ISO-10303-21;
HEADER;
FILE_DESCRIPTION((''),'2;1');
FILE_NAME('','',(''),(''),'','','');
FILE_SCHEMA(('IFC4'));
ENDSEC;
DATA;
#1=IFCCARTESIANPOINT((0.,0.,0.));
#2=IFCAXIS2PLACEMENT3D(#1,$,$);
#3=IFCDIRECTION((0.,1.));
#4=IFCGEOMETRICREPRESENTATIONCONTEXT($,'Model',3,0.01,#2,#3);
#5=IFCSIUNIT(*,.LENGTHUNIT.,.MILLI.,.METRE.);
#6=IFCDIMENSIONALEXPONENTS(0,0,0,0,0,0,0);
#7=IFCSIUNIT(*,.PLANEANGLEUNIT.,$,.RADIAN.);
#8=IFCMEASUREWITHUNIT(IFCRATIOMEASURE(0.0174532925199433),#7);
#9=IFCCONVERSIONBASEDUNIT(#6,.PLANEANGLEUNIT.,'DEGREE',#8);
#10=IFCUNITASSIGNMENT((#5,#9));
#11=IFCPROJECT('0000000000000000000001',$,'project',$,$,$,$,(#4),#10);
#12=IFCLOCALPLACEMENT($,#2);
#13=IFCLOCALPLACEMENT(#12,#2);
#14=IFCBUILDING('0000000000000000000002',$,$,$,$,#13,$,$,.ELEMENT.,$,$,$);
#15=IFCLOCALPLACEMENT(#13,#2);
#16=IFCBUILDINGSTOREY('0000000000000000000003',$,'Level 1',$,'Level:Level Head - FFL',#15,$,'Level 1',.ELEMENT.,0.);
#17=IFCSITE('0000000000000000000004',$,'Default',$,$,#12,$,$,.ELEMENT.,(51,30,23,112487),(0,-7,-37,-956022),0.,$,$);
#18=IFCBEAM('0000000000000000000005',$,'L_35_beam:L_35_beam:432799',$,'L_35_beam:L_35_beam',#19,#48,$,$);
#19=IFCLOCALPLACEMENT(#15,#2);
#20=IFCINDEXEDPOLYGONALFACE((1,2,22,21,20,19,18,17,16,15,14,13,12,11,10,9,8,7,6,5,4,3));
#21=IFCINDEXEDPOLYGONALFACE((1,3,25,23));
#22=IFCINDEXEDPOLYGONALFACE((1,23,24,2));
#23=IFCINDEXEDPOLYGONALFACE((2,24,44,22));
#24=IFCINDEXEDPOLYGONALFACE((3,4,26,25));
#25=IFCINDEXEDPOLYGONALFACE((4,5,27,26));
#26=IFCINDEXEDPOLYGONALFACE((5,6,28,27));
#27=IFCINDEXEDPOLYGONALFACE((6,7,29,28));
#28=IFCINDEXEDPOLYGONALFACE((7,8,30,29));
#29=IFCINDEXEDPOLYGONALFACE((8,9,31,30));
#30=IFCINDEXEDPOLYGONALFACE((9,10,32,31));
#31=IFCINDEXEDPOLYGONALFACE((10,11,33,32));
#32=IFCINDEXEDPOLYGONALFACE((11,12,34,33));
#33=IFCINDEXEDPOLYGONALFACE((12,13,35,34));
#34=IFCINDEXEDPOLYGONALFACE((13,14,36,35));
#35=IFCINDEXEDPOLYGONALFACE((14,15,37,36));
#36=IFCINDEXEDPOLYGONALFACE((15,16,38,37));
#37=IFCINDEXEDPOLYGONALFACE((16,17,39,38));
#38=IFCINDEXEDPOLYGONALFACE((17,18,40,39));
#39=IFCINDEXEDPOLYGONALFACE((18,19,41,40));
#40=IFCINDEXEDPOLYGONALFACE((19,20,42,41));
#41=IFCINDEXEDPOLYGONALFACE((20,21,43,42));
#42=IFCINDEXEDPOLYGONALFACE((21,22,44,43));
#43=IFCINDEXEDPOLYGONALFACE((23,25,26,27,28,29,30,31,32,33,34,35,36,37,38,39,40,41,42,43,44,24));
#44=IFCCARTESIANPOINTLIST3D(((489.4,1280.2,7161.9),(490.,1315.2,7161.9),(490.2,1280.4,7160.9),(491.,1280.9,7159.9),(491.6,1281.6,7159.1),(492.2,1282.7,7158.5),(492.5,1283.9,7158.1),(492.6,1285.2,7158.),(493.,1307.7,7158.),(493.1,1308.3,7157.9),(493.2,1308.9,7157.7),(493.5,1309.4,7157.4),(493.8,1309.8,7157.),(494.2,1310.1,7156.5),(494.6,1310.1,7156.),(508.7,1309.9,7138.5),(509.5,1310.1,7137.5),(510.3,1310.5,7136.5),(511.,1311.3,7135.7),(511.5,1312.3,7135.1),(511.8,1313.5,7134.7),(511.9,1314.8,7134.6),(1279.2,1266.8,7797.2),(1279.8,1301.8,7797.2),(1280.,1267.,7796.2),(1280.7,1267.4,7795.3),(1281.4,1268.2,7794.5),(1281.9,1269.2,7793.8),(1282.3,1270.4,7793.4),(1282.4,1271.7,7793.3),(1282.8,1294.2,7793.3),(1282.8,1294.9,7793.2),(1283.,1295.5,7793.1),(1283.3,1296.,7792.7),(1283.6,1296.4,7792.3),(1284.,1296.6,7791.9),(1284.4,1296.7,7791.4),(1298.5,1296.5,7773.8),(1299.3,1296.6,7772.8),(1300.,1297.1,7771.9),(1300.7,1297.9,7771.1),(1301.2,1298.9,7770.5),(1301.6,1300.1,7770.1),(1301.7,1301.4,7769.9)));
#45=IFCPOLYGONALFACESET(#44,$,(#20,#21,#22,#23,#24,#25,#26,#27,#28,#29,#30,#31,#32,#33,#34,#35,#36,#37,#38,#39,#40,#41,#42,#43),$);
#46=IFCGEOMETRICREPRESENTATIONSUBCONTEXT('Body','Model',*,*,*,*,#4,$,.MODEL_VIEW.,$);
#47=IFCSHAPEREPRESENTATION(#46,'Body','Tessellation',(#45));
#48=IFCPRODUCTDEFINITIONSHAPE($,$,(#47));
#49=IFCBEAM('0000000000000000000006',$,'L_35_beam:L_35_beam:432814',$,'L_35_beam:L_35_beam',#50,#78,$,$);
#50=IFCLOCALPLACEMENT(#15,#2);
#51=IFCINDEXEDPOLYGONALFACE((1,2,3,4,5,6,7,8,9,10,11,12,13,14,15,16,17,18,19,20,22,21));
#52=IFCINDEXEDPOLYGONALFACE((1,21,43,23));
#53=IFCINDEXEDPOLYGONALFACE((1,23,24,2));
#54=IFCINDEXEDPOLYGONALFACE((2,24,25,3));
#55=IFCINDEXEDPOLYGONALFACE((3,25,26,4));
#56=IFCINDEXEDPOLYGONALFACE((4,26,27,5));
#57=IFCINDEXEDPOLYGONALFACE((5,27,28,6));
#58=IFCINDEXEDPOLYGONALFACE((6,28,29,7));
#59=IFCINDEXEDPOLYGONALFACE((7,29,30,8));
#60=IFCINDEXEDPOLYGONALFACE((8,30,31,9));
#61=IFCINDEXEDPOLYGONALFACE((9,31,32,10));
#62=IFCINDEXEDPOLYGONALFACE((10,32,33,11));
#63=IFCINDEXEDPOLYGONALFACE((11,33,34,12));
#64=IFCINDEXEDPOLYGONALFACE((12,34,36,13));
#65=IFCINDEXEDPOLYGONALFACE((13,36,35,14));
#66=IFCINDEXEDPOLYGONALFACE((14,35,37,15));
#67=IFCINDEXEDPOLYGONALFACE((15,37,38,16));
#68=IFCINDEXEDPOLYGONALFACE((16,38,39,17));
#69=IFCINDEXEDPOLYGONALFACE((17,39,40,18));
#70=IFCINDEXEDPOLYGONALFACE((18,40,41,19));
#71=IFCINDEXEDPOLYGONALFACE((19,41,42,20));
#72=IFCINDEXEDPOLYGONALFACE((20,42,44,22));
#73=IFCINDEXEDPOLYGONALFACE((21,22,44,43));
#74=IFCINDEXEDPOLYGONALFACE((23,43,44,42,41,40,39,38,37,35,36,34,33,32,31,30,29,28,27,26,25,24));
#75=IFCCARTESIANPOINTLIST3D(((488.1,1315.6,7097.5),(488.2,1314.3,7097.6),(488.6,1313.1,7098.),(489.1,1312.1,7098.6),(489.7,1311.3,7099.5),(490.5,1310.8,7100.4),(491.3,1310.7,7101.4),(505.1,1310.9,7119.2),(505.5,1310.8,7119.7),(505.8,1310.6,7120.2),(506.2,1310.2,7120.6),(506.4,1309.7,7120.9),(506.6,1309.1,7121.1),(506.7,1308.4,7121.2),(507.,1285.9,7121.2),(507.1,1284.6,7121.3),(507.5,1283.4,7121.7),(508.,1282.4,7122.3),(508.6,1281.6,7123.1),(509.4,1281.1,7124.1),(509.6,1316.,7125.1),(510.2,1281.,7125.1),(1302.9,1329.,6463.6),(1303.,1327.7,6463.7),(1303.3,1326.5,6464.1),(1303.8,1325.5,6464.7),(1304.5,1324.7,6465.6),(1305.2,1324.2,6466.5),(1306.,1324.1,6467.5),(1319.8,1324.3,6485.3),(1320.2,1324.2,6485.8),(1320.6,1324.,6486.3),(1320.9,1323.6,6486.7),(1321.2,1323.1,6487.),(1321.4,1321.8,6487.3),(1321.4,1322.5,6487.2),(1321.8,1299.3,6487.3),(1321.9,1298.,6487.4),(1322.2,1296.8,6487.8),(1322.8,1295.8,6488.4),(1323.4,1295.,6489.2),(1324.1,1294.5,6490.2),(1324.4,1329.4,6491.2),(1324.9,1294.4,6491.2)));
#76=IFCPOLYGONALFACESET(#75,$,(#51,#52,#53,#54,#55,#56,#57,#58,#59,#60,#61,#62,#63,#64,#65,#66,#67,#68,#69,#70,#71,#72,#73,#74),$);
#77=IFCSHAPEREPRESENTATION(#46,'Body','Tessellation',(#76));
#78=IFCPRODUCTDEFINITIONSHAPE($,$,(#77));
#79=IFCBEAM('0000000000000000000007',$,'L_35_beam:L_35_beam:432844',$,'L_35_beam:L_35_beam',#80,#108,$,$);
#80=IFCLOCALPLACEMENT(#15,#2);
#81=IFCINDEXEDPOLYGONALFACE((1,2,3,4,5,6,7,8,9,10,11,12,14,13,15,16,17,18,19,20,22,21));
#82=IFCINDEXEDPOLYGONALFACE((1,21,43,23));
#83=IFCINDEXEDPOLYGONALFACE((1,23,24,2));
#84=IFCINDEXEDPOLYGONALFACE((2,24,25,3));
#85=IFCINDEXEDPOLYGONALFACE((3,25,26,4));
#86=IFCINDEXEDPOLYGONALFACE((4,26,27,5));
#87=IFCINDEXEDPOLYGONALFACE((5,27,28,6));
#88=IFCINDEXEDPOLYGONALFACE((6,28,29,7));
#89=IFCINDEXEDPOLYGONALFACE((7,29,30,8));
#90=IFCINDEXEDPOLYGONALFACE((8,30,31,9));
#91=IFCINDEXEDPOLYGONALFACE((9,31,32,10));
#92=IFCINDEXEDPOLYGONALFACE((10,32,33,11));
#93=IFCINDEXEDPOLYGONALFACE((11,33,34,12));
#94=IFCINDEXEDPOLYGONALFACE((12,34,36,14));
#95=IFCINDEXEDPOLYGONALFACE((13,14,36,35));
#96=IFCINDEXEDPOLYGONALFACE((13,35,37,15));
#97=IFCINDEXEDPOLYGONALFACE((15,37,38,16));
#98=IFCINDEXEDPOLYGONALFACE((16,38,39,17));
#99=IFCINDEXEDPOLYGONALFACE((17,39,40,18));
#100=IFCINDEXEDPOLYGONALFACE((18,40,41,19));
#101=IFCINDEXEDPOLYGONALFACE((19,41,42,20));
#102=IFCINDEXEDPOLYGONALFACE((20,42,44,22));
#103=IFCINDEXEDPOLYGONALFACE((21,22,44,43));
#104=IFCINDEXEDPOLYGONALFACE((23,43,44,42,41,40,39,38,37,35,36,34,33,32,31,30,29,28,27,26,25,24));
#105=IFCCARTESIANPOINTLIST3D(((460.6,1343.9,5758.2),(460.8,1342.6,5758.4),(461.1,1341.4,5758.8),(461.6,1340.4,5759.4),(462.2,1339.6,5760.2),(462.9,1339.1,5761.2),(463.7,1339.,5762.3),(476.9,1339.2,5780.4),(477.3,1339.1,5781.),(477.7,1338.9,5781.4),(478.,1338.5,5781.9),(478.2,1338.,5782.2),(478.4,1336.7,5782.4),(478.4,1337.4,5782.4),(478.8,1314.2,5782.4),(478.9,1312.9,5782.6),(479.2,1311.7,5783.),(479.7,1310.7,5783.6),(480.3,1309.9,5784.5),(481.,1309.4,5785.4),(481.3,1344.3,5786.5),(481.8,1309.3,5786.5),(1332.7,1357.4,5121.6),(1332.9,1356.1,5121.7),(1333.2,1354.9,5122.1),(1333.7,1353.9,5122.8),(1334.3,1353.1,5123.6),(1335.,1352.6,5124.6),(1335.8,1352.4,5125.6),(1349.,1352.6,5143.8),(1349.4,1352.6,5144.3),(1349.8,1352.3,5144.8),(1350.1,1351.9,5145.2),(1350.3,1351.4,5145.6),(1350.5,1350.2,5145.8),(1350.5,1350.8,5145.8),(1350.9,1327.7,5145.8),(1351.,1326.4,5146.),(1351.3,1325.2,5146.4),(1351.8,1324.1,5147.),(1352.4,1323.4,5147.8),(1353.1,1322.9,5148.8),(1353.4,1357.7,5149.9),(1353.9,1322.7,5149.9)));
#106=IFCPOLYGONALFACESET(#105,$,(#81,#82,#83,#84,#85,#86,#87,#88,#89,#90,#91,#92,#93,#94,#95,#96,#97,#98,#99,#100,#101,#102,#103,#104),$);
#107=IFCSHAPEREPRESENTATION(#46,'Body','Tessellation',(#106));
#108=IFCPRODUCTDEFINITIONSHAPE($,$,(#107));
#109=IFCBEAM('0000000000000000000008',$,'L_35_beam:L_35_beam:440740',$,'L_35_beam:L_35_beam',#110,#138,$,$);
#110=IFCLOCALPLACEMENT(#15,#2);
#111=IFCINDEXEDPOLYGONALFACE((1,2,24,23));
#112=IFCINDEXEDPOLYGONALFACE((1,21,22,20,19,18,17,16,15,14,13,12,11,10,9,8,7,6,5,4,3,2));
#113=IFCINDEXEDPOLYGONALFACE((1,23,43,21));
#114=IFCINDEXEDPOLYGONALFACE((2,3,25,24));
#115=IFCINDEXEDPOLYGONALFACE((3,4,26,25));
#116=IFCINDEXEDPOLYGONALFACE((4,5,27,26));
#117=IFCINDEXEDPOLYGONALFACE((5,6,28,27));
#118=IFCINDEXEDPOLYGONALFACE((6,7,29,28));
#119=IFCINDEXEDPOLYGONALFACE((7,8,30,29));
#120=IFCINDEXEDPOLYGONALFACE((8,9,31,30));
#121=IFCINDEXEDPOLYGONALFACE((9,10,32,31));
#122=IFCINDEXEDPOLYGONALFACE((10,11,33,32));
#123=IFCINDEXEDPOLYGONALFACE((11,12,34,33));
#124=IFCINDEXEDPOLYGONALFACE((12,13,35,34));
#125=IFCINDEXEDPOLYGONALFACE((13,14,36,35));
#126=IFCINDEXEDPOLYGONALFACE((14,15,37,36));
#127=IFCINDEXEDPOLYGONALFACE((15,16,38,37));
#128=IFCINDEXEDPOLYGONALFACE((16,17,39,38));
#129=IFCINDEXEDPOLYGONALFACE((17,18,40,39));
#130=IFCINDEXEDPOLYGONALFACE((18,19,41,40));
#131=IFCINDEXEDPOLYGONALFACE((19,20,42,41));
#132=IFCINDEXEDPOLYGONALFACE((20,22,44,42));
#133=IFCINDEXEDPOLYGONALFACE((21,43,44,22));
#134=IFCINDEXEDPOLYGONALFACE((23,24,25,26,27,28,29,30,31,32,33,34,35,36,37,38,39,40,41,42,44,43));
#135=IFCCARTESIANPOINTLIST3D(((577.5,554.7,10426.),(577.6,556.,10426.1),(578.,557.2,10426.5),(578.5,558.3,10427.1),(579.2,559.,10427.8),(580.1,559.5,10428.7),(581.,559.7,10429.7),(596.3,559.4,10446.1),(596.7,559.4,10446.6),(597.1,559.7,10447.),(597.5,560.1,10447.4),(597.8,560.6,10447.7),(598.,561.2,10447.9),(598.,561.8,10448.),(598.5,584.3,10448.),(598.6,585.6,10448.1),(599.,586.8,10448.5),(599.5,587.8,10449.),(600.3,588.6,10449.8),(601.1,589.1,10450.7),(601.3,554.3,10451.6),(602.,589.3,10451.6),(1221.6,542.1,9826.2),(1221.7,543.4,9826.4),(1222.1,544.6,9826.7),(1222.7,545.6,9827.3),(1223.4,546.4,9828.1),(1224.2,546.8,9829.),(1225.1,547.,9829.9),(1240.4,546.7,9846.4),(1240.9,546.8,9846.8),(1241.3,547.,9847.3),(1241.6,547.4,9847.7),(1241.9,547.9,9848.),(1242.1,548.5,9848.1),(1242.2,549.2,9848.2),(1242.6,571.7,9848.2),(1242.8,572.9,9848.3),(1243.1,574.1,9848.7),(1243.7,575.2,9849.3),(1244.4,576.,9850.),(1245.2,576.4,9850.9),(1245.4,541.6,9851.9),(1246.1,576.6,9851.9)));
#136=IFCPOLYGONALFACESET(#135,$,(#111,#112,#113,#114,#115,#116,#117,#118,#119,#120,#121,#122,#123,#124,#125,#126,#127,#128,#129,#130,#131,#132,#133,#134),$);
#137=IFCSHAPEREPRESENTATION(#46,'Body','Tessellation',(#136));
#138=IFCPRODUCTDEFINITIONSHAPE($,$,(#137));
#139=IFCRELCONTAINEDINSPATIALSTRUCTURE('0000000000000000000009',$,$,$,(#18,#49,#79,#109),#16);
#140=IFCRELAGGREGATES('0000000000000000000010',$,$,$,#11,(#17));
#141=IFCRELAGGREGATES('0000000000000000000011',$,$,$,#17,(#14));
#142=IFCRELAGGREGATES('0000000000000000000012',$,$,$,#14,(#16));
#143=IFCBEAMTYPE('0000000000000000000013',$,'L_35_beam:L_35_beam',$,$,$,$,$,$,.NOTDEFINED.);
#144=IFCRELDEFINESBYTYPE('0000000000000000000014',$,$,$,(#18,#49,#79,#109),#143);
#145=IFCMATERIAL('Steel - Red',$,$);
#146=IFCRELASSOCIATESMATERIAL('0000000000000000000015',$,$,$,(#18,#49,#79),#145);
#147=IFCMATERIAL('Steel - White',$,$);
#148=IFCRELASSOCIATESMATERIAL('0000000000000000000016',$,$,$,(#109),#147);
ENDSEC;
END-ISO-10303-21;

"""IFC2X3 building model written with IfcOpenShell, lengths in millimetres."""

from ifc_helpers import new_model, entity, si_unit, converted_unit, direction, frame, frame_2d, origin, place, context, subcontext, project, spatial, polyline, circle_curve, parameter, trimmed, segment, composite_curve, outline, extrude, material, type_object, element, save


model = new_model("IFC2X3")

# Units and contexts
model_context = context("Model", 3, precision=0.01, world=origin(), true_north=direction((0.0, 1.0)))
body_context = subcontext(model_context, "Body", "Model", "MODEL_VIEW")
ifc_project = project(units=[si_unit("LENGTHUNIT", "METRE", prefix="MILLI"), converted_unit("PLANEANGLEUNIT", "DEGREE", entity("IfcRatioMeasure", 0.0174532925199433), si_unit("PLANEANGLEUNIT", "RADIAN"), dimensions=[0, 0, 0, 0, 0, 0, 0])], contexts=[model_context])

# Site, building, storey
site_placement = place(None, origin())
site = spatial("IfcSite", under=ifc_project, at=site_placement, Name="Default", CompositionType="ELEMENT", RefLatitude=(51, 30, 23, 112487), RefLongitude=(0, -7, -37, -956022), RefElevation=0.0)
building_placement = place(site_placement, origin())
building = spatial("IfcBuilding", under=site, at=building_placement, CompositionType="ELEMENT")
storey_placement = place(building_placement, origin())
storey = spatial("IfcBuildingStorey", under=building, at=storey_placement, Name="Level 1", ObjectType="Level:Level Head - FFL", LongName="Level 1", CompositionType="ELEMENT", Elevation=0.0)

# Beams
ifc_material_1 = material(Name="Steel - Red")
ifc_material_2 = material(Name="Steel - White")
beam_type_1 = type_object("IfcBeamType", Name="L_35_beam:L_35_beam", PredefinedType="NOTDEFINED")
beam_1_placement = place(storey_placement, frame((476.6, 1323.4, 7128.5), z_axis=(-0.626668, 0.010652, 0.779213), x_axis=(0.779101, -0.013243, 0.626759)))
element("IfcBeam", 1, at=beam_1_placement, inside=storey, type_object=beam_type_1, material=ifc_material_1, Name="L_35_beam:L_35_beam:432799", ObjectType="L_35_beam:L_35_beam", context=body_context, shape_type="SweptSolid", body=[
    extrude(outline(composite_curve([segment(polyline([(-23.2, -11.8), (11.8, -11.8)]), True, "CONTINUOUS"), segment(polyline([(11.8, -11.8), (11.8, 23.2)]), True, "CONTINUOUS"), segment(trimmed(circle_curve(frame_2d((11.8, 18.2), x_axis=(0.0, 1.0)), 5.0), [parameter(0.0)], [parameter(90.0)], True, "PARAMETER"), True, "CONTINUOUS"), segment(polyline([(6.8, 18.2), (6.8, -4.3)]), True, "CONTINUOUS"), segment(trimmed(circle_curve(frame_2d((4.3, -4.3), x_axis=(1.0, 0.0)), 2.5), [parameter(270.0)], [parameter(0.0)], True, "PARAMETER"), False, "CONTINUOUS"), segment(polyline([(4.3, -6.8), (-18.2, -6.8)]), True, "CONTINUOUS"), segment(trimmed(circle_curve(frame_2d((-18.2, -11.8), x_axis=(0.0, 1.0)), 5.0), [parameter(0.0)], [parameter(90.0)], True, "PARAMETER"), True, "CONTINUOUS")], self_intersect=False)), frame((31.5, -19.8, 5.7), z_axis=(1.0, 0.0, 0.0), x_axis=(0.0, 0.0, 1.0)), (0.0, 0.0, 1.0), 1013.7),
])
beam_2_placement = place(storey_placement, frame((476.6, 1323.4, 7128.5), z_axis=(0.61392, 0.010092, 0.789304), x_axis=(0.789197, 0.012974, -0.614003)))
element("IfcBeam", 2, at=beam_2_placement, inside=storey, type_object=beam_type_1, material=ifc_material_1, Name="L_35_beam:L_35_beam:432814", ObjectType="L_35_beam:L_35_beam", context=body_context, shape_type="SweptSolid", body=[
    extrude(outline(composite_curve([segment(polyline([(-23.2, -11.8), (11.8, -11.8)]), True, "CONTINUOUS"), segment(polyline([(11.8, -11.8), (11.8, 23.2)]), True, "CONTINUOUS"), segment(trimmed(circle_curve(frame_2d((11.8, 18.2), x_axis=(0.0, 1.0)), 5.0), [parameter(0.0)], [parameter(90.0)], True, "PARAMETER"), True, "CONTINUOUS"), segment(polyline([(6.8, 18.2), (6.8, -4.3)]), True, "CONTINUOUS"), segment(trimmed(circle_curve(frame_2d((4.3, -4.3), x_axis=(1.0, 0.0)), 2.5), [parameter(270.0)], [parameter(0.0)], True, "PARAMETER"), False, "CONTINUOUS"), segment(polyline([(4.3, -6.8), (-18.2, -6.8)]), True, "CONTINUOUS"), segment(trimmed(circle_curve(frame_2d((-18.2, -11.8), x_axis=(0.0, 1.0)), 5.0), [parameter(0.0)], [parameter(90.0)], True, "PARAMETER"), True, "CONTINUOUS")], self_intersect=False)), frame((28.0, -19.8, 5.7), z_axis=(1.0, 0.0, 0.0), x_axis=(0.0, 0.0, 1.0)), (0.0, 0.0, 1.0), 1032.4),
])
beam_3_placement = place(storey_placement, frame((448.3, 1351.8, 5788.8), z_axis=(0.589494, 0.009093, 0.807721), x_axis=(0.807625, 0.012457, -0.589564)))
element("IfcBeam", 3, at=beam_3_placement, inside=storey, type_object=beam_type_1, material=ifc_material_1, Name="L_35_beam:L_35_beam:432844", ObjectType="L_35_beam:L_35_beam", context=body_context, shape_type="SweptSolid", body=[
    extrude(outline(composite_curve([segment(polyline([(-23.2, -11.8), (11.8, -11.8)]), True, "CONTINUOUS"), segment(polyline([(11.8, -11.8), (11.8, 23.2)]), True, "CONTINUOUS"), segment(trimmed(circle_curve(frame_2d((11.8, 18.2), x_axis=(0.0, 1.0)), 5.0), [parameter(0.0)], [parameter(90.0)], True, "PARAMETER"), True, "CONTINUOUS"), segment(polyline([(6.8, 18.2), (6.8, -4.3)]), True, "CONTINUOUS"), segment(trimmed(circle_curve(frame_2d((4.3, -4.3), x_axis=(1.0, 0.0)), 2.5), [parameter(270.0)], [parameter(0.0)], True, "PARAMETER"), False, "CONTINUOUS"), segment(polyline([(4.3, -6.8), (-18.2, -6.8)]), True, "CONTINUOUS"), segment(trimmed(circle_curve(frame_2d((-18.2, -11.8), x_axis=(0.0, 1.0)), 5.0), [parameter(0.0)], [parameter(90.0)], True, "PARAMETER"), True, "CONTINUOUS")], self_intersect=False)), frame((27.9, -19.8, 5.7), z_axis=(1.0, 0.0, 0.0), x_axis=(0.0, 0.0, 1.0)), (0.0, 0.0, 1.0), 1079.8),
])
beam_4_placement = place(storey_placement, frame((1266.8, 533.2, 9807.9), z_axis=(0.681245, -0.013403, 0.731933), x_axis=(-0.731791, 0.014397, 0.681377)))
element("IfcBeam", 4, at=beam_4_placement, inside=storey, type_object=beam_type_1, material=ifc_material_2, Name="L_35_beam:L_35_beam:440740", ObjectType="L_35_beam:L_35_beam", context=body_context, shape_type="SweptSolid", body=[
    extrude(outline(composite_curve([segment(polyline([(-23.2, -11.8), (11.8, -11.8)]), True, "CONTINUOUS"), segment(polyline([(11.8, -11.8), (11.8, 23.2)]), True, "CONTINUOUS"), segment(trimmed(circle_curve(frame_2d((11.8, 18.2), x_axis=(0.0, 1.0)), 5.0), [parameter(0.0)], [parameter(90.0)], True, "PARAMETER"), True, "CONTINUOUS"), segment(polyline([(6.8, 18.2), (6.8, -4.3)]), True, "CONTINUOUS"), segment(trimmed(circle_curve(frame_2d((4.3, -4.3), x_axis=(1.0, 0.0)), 2.5), [parameter(270.0)], [parameter(0.0)], True, "PARAMETER"), False, "CONTINUOUS"), segment(polyline([(4.3, -6.8), (-18.2, -6.8)]), True, "CONTINUOUS"), segment(trimmed(circle_curve(frame_2d((-18.2, -11.8), x_axis=(0.0, 1.0)), 5.0), [parameter(0.0)], [parameter(90.0)], True, "PARAMETER"), True, "CONTINUOUS")], self_intersect=False)), frame((45.7, -19.8, 5.7), z_axis=(1.0, 0.0, 0.0), x_axis=(0.0, 0.0, 1.0)), (0.0, 0.0, 1.0), 880.2),
])

save(model, "model.ifc")
